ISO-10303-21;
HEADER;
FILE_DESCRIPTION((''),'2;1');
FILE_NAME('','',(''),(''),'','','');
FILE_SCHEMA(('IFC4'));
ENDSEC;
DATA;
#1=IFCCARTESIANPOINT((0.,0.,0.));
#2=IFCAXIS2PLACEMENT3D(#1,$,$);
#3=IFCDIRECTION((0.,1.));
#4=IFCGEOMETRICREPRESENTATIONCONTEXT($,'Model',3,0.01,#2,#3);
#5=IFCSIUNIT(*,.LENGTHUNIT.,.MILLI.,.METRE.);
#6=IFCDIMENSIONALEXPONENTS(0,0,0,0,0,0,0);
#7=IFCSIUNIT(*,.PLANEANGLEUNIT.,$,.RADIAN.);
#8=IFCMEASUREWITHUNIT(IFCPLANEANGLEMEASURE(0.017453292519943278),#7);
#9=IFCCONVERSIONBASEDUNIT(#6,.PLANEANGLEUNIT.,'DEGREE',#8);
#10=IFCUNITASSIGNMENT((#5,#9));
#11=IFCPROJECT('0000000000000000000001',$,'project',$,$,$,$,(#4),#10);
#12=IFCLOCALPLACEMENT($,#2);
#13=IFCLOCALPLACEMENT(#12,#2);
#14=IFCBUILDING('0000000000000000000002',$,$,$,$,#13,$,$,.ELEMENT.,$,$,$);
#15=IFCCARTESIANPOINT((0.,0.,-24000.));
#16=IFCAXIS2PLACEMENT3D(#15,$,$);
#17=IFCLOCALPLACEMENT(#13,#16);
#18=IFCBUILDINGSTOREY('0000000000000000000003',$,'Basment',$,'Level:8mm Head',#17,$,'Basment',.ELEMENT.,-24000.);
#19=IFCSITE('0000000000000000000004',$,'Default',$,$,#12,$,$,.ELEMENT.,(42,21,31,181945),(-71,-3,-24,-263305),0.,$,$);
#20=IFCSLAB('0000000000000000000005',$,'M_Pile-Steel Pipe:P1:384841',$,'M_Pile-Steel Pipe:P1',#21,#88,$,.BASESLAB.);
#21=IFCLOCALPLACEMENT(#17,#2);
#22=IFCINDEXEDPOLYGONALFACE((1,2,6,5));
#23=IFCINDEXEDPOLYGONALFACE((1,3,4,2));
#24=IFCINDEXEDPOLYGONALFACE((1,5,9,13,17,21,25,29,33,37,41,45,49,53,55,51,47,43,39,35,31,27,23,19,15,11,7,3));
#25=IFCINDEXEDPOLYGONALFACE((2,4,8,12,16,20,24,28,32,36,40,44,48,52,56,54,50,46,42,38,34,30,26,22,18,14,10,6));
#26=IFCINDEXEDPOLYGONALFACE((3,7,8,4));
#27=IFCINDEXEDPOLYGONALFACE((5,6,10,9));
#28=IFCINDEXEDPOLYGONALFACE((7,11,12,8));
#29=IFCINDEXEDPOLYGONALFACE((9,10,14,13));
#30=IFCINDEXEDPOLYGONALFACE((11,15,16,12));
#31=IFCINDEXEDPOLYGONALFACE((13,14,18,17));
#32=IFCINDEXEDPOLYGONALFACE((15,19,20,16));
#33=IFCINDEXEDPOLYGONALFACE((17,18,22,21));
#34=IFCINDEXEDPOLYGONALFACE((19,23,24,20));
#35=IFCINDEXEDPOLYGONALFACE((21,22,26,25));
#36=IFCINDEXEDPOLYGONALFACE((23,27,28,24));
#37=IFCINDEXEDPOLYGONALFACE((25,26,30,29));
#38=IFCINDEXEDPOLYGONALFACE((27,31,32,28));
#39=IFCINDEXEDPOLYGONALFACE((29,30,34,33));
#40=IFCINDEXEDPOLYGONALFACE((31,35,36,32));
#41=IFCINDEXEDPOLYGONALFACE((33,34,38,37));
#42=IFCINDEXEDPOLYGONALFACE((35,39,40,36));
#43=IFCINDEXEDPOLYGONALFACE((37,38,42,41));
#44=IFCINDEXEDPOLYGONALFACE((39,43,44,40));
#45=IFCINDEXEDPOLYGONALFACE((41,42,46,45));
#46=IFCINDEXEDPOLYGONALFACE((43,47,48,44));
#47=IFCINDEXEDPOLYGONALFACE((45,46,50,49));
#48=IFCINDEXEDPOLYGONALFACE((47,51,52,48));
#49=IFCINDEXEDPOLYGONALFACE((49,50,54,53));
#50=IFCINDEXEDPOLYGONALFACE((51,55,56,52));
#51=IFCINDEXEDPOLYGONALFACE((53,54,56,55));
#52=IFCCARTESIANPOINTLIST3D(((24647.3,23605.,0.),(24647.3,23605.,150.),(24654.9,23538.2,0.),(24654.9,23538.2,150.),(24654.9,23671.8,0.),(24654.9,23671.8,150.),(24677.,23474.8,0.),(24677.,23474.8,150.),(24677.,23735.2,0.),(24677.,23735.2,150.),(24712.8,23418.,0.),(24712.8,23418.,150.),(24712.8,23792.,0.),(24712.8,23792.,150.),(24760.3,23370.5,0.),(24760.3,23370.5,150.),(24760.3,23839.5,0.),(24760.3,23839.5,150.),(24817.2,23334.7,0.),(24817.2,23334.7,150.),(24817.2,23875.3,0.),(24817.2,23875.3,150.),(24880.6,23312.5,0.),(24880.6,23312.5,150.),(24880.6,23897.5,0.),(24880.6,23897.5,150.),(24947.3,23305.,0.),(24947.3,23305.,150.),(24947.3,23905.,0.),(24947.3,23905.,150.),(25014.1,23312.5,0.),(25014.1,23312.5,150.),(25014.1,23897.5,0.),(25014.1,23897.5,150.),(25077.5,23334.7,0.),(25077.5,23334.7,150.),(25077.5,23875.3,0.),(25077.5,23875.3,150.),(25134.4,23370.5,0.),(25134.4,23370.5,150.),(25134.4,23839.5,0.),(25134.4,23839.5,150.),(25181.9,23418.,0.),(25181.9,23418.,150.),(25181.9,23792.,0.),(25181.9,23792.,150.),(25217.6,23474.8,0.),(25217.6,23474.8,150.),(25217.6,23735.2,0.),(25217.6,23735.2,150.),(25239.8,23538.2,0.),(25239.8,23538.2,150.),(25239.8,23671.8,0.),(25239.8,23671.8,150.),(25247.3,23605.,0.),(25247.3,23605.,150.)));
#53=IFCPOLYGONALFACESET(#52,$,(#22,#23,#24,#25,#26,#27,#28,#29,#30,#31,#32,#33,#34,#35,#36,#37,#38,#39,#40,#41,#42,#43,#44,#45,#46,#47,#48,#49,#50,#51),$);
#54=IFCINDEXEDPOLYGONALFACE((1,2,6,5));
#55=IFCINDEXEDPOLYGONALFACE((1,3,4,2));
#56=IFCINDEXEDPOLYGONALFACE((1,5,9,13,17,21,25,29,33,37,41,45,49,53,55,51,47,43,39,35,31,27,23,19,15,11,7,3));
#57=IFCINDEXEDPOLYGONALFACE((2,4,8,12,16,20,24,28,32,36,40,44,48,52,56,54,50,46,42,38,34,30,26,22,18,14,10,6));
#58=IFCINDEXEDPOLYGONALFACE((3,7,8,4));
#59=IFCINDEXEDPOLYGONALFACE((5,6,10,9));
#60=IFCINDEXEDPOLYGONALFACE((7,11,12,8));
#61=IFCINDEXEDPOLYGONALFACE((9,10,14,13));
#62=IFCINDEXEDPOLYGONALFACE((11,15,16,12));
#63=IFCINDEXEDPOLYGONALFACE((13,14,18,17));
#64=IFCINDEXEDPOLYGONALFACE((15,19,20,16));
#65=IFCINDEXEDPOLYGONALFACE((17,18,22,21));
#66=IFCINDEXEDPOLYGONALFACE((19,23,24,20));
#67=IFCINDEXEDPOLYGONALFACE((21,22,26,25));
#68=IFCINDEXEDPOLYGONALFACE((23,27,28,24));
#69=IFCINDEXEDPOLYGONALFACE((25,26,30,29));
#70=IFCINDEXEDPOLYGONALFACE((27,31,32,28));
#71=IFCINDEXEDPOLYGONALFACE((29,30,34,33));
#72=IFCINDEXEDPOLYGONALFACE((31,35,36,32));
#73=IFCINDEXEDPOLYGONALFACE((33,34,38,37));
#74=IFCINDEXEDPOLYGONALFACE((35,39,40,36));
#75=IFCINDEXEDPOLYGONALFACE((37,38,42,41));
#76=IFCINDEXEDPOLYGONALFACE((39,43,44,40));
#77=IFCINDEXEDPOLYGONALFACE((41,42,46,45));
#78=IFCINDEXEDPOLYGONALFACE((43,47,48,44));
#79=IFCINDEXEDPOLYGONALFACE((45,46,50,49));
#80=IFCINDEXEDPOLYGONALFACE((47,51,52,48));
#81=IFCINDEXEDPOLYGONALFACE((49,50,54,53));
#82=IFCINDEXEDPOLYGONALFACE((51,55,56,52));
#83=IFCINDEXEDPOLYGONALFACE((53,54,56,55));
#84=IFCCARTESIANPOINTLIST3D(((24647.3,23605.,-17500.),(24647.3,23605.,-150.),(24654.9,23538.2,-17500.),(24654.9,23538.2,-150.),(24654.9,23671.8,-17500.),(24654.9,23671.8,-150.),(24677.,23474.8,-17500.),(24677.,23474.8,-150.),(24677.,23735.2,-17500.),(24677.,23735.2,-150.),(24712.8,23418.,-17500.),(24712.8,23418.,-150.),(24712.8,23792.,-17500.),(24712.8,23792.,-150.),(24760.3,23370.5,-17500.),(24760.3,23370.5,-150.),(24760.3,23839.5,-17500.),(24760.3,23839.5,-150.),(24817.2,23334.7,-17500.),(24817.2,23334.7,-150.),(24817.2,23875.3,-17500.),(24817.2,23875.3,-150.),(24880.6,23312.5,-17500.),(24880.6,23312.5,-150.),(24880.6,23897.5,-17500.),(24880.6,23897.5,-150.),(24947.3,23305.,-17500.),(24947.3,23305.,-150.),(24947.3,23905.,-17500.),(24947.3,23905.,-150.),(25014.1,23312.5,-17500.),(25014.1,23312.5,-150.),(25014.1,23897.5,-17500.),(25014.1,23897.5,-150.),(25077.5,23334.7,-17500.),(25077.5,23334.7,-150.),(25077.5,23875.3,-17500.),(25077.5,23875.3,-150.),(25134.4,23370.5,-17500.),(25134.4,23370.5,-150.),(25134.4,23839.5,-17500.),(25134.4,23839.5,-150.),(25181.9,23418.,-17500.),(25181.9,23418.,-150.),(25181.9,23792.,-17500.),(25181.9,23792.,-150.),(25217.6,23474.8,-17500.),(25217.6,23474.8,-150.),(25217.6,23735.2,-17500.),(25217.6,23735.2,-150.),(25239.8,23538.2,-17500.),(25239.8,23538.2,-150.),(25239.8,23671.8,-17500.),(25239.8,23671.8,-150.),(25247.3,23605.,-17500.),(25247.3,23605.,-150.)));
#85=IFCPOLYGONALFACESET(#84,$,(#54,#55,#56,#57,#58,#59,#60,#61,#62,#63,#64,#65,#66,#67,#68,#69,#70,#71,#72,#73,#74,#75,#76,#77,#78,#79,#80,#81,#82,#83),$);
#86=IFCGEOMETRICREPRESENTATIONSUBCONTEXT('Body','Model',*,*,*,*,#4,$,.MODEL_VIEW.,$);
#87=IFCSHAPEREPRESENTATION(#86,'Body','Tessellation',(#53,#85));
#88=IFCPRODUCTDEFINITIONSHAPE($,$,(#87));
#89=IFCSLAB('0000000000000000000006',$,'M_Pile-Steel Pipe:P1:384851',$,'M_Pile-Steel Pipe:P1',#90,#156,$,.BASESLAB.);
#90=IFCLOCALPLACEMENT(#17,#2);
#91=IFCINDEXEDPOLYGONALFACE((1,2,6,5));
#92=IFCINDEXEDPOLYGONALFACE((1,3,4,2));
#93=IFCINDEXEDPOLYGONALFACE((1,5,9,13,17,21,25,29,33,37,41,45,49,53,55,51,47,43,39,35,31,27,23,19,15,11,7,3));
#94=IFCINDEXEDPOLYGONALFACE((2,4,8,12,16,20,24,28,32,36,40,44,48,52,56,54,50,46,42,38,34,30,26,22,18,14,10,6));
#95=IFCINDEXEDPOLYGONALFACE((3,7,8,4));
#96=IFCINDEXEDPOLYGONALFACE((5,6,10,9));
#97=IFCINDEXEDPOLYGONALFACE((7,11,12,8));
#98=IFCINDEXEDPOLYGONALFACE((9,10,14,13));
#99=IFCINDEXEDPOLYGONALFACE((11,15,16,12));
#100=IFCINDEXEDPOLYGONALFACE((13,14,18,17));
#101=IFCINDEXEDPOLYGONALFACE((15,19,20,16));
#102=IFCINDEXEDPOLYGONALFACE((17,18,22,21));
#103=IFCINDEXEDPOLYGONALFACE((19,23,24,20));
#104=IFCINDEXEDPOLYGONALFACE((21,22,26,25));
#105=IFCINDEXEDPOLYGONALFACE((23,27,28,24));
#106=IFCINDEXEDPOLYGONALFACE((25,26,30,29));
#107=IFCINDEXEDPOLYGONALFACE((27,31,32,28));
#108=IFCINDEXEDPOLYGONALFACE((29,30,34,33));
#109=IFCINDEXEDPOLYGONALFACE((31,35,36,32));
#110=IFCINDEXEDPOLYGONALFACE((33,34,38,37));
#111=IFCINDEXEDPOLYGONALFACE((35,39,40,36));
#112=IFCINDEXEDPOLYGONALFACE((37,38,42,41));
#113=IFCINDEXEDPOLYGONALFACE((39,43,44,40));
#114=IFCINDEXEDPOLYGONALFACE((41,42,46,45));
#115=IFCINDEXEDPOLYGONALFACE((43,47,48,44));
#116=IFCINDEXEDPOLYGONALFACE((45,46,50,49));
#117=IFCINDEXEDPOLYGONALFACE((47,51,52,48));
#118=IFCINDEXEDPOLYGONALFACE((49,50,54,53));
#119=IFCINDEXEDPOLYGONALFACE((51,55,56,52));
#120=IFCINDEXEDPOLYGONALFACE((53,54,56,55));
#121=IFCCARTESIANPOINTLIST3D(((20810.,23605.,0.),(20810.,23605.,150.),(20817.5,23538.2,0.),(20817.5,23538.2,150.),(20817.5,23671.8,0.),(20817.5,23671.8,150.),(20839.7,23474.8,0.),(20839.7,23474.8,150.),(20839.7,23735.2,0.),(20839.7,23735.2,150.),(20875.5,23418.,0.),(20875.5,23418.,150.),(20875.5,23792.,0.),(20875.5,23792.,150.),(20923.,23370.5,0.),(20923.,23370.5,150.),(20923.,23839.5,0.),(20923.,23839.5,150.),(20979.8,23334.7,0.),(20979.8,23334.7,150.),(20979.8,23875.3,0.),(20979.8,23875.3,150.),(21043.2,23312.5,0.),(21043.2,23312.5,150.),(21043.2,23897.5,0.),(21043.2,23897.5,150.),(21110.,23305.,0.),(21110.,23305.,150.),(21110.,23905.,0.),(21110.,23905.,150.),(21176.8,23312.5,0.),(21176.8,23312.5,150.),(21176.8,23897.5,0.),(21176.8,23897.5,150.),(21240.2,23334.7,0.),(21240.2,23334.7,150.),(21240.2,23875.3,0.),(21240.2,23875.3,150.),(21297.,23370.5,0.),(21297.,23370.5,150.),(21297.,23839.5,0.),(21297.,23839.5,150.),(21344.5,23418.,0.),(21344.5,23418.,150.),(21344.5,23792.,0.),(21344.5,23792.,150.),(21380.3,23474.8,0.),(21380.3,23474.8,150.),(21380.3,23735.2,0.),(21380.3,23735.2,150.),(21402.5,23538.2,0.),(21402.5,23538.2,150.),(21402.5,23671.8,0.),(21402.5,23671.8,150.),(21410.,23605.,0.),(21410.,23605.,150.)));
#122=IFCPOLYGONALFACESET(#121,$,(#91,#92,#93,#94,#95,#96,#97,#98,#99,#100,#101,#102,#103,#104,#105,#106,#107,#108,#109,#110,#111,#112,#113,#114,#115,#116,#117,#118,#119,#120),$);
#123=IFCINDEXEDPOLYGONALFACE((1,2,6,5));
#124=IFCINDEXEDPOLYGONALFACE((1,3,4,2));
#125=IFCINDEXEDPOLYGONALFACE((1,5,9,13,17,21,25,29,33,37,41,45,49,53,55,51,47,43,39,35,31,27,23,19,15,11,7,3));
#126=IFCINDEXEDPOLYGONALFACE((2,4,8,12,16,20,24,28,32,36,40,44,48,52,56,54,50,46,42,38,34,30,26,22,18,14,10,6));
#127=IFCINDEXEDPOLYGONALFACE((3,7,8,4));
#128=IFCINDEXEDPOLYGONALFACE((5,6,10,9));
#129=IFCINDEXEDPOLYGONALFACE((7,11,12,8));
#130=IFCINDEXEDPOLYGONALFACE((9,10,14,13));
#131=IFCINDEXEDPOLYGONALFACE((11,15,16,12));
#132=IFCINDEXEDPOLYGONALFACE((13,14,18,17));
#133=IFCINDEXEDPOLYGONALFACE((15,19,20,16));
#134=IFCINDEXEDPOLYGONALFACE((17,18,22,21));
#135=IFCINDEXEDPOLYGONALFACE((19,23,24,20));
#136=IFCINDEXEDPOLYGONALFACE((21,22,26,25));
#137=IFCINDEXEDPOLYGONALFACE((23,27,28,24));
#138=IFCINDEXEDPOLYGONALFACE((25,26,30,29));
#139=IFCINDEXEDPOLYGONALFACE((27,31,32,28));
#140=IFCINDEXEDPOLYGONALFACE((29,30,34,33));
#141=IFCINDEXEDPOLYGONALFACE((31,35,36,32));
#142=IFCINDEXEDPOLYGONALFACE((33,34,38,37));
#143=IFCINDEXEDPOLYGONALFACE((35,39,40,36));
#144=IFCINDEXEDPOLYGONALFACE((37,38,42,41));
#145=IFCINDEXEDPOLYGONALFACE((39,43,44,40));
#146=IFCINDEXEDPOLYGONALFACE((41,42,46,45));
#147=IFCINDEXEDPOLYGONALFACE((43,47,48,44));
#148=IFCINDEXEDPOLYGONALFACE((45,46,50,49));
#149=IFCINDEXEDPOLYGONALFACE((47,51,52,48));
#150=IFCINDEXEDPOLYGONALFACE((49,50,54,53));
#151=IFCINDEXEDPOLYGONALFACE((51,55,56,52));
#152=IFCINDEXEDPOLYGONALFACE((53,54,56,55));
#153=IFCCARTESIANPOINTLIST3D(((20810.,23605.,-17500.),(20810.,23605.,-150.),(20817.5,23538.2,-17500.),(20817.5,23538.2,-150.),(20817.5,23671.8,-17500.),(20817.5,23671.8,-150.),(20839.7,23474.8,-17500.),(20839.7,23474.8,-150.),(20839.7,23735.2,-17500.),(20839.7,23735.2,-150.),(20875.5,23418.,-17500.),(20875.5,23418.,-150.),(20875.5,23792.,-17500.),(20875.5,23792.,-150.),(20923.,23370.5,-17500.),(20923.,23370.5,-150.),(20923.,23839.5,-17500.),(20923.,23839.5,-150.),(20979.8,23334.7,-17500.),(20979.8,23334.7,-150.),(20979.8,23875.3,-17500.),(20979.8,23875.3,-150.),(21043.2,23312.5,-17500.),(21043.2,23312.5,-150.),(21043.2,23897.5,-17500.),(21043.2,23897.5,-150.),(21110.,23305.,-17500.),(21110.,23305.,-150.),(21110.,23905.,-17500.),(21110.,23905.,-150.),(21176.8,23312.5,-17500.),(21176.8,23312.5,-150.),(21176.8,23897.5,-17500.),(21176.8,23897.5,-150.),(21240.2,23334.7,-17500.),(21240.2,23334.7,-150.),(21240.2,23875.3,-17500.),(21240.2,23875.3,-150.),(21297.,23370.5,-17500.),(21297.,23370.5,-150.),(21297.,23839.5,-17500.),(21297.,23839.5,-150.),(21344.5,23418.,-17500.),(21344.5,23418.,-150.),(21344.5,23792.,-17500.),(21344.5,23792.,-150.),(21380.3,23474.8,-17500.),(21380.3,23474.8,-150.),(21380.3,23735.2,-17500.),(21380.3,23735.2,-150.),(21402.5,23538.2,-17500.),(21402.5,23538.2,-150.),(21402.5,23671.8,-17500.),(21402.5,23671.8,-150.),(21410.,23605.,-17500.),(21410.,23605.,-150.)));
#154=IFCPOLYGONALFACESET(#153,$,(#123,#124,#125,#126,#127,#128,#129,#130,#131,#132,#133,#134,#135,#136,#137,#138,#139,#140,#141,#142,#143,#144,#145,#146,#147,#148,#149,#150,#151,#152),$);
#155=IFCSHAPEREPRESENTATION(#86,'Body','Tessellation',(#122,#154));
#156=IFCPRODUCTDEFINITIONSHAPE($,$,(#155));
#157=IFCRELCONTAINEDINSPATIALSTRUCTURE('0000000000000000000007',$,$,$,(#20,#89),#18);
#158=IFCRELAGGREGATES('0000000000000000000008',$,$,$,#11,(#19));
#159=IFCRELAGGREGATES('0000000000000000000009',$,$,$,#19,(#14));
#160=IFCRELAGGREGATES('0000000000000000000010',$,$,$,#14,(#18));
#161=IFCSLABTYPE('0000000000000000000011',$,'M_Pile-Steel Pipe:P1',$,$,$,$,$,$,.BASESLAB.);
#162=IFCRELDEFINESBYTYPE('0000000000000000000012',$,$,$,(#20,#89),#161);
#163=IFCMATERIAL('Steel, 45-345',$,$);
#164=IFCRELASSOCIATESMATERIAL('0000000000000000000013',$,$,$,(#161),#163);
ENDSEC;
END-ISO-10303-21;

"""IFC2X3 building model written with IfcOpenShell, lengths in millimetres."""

from ifc_helpers import new_model, entity, si_unit, converted_unit, direction, frame, origin, origin_2d_with_axis, place, context, subcontext, project, spatial, circle, extrude, material, type_object, element, save


model = new_model("IFC2X3")

# Units and contexts
model_context = context("Model", 3, precision=0.01, world=origin(), true_north=direction((0.0, 1.0)))
body_context = subcontext(model_context, "Body", "Model", "MODEL_VIEW")
ifc_project = project(units=[si_unit("LENGTHUNIT", "METRE", prefix="MILLI"), converted_unit("PLANEANGLEUNIT", "DEGREE", entity("IfcPlaneAngleMeasure", 0.017453292519943278), si_unit("PLANEANGLEUNIT", "RADIAN"), dimensions=[0, 0, 0, 0, 0, 0, 0])], contexts=[model_context])

# Site, building, storey
site_placement = place(None, origin())
site = spatial("IfcSite", under=ifc_project, at=site_placement, Name="Default", CompositionType="ELEMENT", RefLatitude=(42, 21, 31, 181945), RefLongitude=(-71, -3, -24, -263305), RefElevation=0.0)
building_placement = place(site_placement, origin())
building = spatial("IfcBuilding", under=site, at=building_placement, CompositionType="ELEMENT")
storey_placement = place(building_placement, frame((0.0, 0.0, -24000.0)))
storey = spatial("IfcBuildingStorey", under=building, at=storey_placement, Name="Basment", ObjectType="Level:8mm Head", LongName="Basment", CompositionType="ELEMENT", Elevation=-24000.0)

# Slabs
ifc_material_1 = material(Name="Steel, 45-345")
slab_type_1 = type_object("IfcSlabType", Name="M_Pile-Steel Pipe:P1", PredefinedType="BASESLAB", material=ifc_material_1)
slab_1_placement = place(storey_placement, origin())
element("IfcSlab", 1, at=slab_1_placement, inside=storey, type_object=slab_type_1, Name="M_Pile-Steel Pipe:P1:384841", ObjectType="M_Pile-Steel Pipe:P1", PredefinedType="BASESLAB", context=body_context, shape_type="SweptSolid", body=[
    extrude(circle(Radius=300.0, at=origin_2d_with_axis()), frame((24947.3, 23605.0, 0.0), z_axis=(0.0, 0.0, 1.0), x_axis=(0.0, 1.0, 0.0)), (0.0, 0.0, 1.0), 150.0),
    extrude(circle(Radius=300.0, at=origin_2d_with_axis()), frame((24947.3, 23605.0, -17500.0), z_axis=(0.0, 0.0, 1.0), x_axis=(0.0, 1.0, 0.0)), (0.0, 0.0, 1.0), 17350.0),
])
slab_2_placement = place(storey_placement, origin())
element("IfcSlab", 2, at=slab_2_placement, inside=storey, type_object=slab_type_1, Name="M_Pile-Steel Pipe:P1:384851", ObjectType="M_Pile-Steel Pipe:P1", PredefinedType="BASESLAB", context=body_context, shape_type="SweptSolid", body=[
    extrude(circle(Radius=300.0, at=origin_2d_with_axis()), frame((21110.0, 23605.0, 0.0), z_axis=(0.0, 0.0, 1.0), x_axis=(0.0, 1.0, 0.0)), (0.0, 0.0, 1.0), 150.0),
    extrude(circle(Radius=300.0, at=origin_2d_with_axis()), frame((21110.0, 23605.0, -17500.0), z_axis=(0.0, 0.0, 1.0), x_axis=(0.0, 1.0, 0.0)), (0.0, 0.0, 1.0), 17350.0),
])

save(model, "model.ifc")
